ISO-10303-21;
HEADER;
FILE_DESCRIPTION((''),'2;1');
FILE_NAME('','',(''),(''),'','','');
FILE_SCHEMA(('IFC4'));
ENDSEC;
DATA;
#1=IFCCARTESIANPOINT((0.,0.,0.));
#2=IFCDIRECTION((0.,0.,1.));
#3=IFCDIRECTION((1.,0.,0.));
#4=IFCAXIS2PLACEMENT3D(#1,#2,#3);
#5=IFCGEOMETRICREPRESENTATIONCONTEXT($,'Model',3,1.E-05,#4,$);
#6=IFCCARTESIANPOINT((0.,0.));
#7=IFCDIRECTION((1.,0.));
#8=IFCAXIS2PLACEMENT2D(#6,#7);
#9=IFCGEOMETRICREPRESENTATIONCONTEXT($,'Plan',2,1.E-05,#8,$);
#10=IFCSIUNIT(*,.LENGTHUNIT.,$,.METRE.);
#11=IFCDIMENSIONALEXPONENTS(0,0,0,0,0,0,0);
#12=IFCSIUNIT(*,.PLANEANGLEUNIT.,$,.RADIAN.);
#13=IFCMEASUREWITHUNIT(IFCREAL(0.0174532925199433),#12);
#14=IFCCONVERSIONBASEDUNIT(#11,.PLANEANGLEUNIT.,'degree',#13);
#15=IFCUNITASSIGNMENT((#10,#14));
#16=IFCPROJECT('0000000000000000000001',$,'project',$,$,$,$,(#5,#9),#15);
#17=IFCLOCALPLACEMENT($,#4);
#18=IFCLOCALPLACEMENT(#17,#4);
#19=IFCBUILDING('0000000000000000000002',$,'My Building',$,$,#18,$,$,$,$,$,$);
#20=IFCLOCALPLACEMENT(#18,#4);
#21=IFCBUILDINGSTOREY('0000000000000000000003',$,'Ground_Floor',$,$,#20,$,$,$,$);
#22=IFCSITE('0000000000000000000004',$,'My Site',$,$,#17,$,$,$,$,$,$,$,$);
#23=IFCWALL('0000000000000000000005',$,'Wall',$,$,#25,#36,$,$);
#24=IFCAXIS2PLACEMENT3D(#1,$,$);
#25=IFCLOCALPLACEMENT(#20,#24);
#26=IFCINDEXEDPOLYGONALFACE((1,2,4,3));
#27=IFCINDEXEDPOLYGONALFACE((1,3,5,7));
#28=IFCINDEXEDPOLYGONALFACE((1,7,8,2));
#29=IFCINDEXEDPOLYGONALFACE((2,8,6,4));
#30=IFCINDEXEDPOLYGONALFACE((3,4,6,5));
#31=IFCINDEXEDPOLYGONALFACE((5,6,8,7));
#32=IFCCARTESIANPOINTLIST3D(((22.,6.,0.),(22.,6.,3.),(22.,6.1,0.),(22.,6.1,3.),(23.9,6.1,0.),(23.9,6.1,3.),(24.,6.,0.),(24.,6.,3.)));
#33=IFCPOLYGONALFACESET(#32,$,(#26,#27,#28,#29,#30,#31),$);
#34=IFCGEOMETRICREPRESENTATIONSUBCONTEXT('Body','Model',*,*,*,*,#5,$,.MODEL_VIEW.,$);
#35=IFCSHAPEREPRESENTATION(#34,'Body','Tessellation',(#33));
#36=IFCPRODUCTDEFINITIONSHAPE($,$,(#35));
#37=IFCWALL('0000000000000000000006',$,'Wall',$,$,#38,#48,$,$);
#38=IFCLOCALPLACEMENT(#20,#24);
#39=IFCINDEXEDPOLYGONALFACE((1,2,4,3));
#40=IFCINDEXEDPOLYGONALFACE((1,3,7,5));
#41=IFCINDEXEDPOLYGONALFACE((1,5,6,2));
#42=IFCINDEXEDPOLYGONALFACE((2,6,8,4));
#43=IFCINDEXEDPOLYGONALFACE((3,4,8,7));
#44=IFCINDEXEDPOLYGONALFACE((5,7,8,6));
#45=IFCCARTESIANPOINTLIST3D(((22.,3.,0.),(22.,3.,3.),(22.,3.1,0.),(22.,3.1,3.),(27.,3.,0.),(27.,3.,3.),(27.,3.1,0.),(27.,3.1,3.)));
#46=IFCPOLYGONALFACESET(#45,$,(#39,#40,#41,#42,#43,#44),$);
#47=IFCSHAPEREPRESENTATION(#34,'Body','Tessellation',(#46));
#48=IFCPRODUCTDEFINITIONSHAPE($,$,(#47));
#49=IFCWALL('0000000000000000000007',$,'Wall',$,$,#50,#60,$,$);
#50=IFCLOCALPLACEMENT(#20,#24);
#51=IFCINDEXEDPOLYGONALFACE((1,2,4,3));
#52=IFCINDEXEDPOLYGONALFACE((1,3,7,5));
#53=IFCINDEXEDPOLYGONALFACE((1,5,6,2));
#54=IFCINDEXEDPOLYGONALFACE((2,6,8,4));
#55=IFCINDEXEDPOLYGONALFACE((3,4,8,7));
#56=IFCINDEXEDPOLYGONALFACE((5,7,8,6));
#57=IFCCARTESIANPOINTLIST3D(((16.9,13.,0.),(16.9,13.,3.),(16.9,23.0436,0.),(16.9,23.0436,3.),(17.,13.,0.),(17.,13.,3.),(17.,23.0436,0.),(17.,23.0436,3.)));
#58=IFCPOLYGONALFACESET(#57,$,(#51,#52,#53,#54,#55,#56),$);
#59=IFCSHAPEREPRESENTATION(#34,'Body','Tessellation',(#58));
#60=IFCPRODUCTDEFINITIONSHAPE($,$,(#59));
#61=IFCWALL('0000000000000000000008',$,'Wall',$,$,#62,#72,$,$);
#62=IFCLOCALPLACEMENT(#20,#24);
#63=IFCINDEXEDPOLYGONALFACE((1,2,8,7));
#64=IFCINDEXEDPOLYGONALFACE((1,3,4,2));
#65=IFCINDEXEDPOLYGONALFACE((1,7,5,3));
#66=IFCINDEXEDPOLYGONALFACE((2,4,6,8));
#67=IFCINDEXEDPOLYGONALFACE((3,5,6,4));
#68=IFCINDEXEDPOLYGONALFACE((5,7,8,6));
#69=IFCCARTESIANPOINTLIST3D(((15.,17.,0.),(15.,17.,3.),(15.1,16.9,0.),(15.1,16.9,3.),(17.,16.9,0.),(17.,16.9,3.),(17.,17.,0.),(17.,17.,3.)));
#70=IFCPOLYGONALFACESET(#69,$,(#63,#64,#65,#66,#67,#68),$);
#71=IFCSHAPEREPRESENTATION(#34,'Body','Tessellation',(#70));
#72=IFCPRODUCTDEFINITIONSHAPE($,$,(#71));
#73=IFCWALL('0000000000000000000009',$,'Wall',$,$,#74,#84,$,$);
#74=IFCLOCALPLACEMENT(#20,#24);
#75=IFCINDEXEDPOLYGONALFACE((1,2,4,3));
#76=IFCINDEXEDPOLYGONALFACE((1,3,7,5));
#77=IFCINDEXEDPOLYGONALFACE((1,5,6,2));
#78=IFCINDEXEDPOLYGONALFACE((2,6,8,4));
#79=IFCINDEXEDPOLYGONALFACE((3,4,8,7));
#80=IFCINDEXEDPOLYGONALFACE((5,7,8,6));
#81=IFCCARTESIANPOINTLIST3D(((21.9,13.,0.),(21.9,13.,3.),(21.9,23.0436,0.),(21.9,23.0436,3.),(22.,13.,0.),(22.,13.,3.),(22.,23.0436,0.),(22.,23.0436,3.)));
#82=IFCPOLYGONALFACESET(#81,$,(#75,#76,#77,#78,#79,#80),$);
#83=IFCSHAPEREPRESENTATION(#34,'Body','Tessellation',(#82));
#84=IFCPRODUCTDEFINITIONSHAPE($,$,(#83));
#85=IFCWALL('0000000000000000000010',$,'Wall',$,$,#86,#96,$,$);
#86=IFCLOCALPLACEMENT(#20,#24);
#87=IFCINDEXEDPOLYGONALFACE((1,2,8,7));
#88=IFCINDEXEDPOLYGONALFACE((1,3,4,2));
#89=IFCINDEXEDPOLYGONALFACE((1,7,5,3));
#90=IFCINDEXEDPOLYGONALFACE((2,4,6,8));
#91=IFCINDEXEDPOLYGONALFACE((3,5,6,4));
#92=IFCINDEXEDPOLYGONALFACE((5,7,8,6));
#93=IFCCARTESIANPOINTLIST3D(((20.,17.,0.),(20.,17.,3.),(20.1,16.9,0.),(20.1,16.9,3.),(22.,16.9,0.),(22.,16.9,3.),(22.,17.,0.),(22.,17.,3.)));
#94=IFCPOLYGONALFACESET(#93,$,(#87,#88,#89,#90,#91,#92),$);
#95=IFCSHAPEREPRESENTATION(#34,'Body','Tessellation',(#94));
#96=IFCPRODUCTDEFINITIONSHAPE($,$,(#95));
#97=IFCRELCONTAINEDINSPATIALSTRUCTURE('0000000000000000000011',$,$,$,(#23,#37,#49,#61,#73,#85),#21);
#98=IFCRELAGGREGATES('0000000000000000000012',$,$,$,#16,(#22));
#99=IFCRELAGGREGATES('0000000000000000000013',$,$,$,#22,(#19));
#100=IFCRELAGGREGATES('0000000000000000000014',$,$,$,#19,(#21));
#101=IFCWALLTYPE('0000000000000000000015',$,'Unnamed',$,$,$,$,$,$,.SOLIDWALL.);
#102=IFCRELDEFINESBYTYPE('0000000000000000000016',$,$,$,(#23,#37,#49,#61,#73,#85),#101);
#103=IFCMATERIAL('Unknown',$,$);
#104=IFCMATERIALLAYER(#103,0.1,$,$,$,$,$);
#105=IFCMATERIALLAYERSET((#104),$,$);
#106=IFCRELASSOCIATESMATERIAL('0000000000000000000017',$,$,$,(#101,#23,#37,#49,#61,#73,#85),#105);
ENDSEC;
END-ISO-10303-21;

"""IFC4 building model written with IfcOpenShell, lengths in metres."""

from ifc_helpers import new_model, entity, si_unit, converted_unit, frame, origin_with_axes, origin_2d_with_axis, place, context, subcontext, project, spatial, line, indexed_curve, outline, extrude, material, layer, layer_set, layer_usage, type_object, element, save


model = new_model("IFC4")

# Units and contexts
model_context = context("Model", 3, precision=1e-05, world=origin_with_axes())
plan_context = context("Plan", 2, precision=1e-05, world=origin_2d_with_axis())
body_context_1 = subcontext(model_context, "Body", "Model", "MODEL_VIEW")
ifc_project = project(units=[si_unit("LENGTHUNIT", "METRE"), converted_unit("PLANEANGLEUNIT", "degree", entity("IfcReal", 0.0174532925199433), si_unit("PLANEANGLEUNIT", "RADIAN"), dimensions=[0, 0, 0, 0, 0, 0, 0])], contexts=[model_context, plan_context])

# Site, building, storey
site_placement = place(None, origin_with_axes())
site = spatial("IfcSite", under=ifc_project, at=site_placement, Name="My Site")
building_placement = place(site_placement, origin_with_axes())
building = spatial("IfcBuilding", under=site, at=building_placement, Name="My Building")
storey_placement = place(building_placement, origin_with_axes())
storey = spatial("IfcBuildingStorey", under=building, at=storey_placement, Name="Ground_Floor")

# Shared definitions
ifc_material = material(Name="Unknown")
ifc_layer = layer(ifc_material, 0.1)
ifc_layer_set = layer_set([ifc_layer])
wall_type = type_object("IfcWallType", Name="Unnamed", PredefinedType="SOLIDWALL", material=ifc_layer_set)

# Walls
ifc_layer_usage_1 = layer_usage(ifc_layer_set, "AXIS2", "POSITIVE", 0.0)
wall_1_placement = place(storey_placement, frame((22.0, 6.0, 0.0), z_axis=(0.0, 0.0, 1.0), x_axis=(1.0, 0.0, 0.0)))
element("IfcWall", 1, at=wall_1_placement, inside=storey, type_object=wall_type, material=ifc_layer_usage_1, Name="Wall", context=body_context_1, shape_type="SweptSolid", body=[
    extrude(outline(indexed_curve([(0.0, 0.0), (0.0, 0.1), (1.9, 0.1), (2.0, 0.0)], segments=[line(1, 2, 3, 4, 1)])), origin_with_axes(), (0.0, 0.0, 1.0), 3.0),
])
ifc_layer_usage_2 = layer_usage(ifc_layer_set, "AXIS2", "POSITIVE", 0.0)
wall_2_placement = place(storey_placement, frame((22.0, 3.0, 0.0), z_axis=(0.0, 0.0, 1.0), x_axis=(1.0, 0.0, 0.0)))
element("IfcWall", 2, at=wall_2_placement, inside=storey, type_object=wall_type, material=ifc_layer_usage_2, Name="Wall", context=body_context_1, shape_type="SweptSolid", body=[
    extrude(outline(indexed_curve([(0.0, 0.0), (0.0, 0.1), (5.0, 0.1), (5.0, 0.0)], segments=[line(1, 2, 3, 4, 1)])), origin_with_axes(), (0.0, 0.0, 1.0), 3.0),
])
ifc_layer_usage_3 = layer_usage(ifc_layer_set, "AXIS2", "POSITIVE", 0.0)
wall_3_placement = place(storey_placement, frame((17.0, 13.0, 0.0), z_axis=(0.0, 0.0, 1.0), x_axis=(0.0, 1.0, 0.0)))
element("IfcWall", 3, at=wall_3_placement, inside=storey, type_object=wall_type, material=ifc_layer_usage_3, Name="Wall", context=body_context_1, shape_type="SweptSolid", body=[
    extrude(outline(indexed_curve([(0.0, 0.0), (0.0, 0.1), (10.0436, 0.1), (10.0436, 0.0)], segments=[line(1, 2, 3, 4, 1)])), origin_with_axes(), (0.0, 0.0, 1.0), 3.0),
])
ifc_layer_usage_4 = layer_usage(ifc_layer_set, "AXIS2", "POSITIVE", 0.0)
wall_4_placement = place(storey_placement, frame((17.0, 17.0, 0.0), z_axis=(0.0, 0.0, 1.0), x_axis=(-1.0, 0.0, 0.0)))
element("IfcWall", 4, at=wall_4_placement, inside=storey, type_object=wall_type, material=ifc_layer_usage_4, Name="Wall", context=body_context_1, shape_type="SweptSolid", body=[
    extrude(outline(indexed_curve([(0.0, 0.0), (0.0, 0.1), (1.9, 0.1), (2.0, 0.0)], segments=[line(1, 2, 3, 4, 1)])), origin_with_axes(), (0.0, 0.0, 1.0), 3.0),
])
ifc_layer_usage_5 = layer_usage(ifc_layer_set, "AXIS2", "POSITIVE", 0.0)
wall_5_placement = place(storey_placement, frame((22.0, 13.0, 0.0), z_axis=(0.0, 0.0, 1.0), x_axis=(0.0, 1.0, 0.0)))
element("IfcWall", 5, at=wall_5_placement, inside=storey, type_object=wall_type, material=ifc_layer_usage_5, Name="Wall", context=body_context_1, shape_type="SweptSolid", body=[
    extrude(outline(indexed_curve([(0.0, 0.0), (0.0, 0.1), (10.0436, 0.1), (10.0436, 0.0)], segments=[line(1, 2, 3, 4, 1)])), origin_with_axes(), (0.0, 0.0, 1.0), 3.0),
])
ifc_layer_usage_6 = layer_usage(ifc_layer_set, "AXIS2", "POSITIVE", 0.0)
wall_6_placement = place(storey_placement, frame((22.0, 17.0, 0.0), z_axis=(0.0, 0.0, 1.0), x_axis=(-1.0, 0.0, 0.0)))
element("IfcWall", 6, at=wall_6_placement, inside=storey, type_object=wall_type, material=ifc_layer_usage_6, Name="Wall", context=body_context_1, shape_type="SweptSolid", body=[
    extrude(outline(indexed_curve([(0.0, 0.0), (0.0, 0.1), (1.9, 0.1), (2.0, 0.0)], segments=[line(1, 2, 3, 4, 1)])), origin_with_axes(), (0.0, 0.0, 1.0), 3.0),
])

save(model, "model.ifc")
